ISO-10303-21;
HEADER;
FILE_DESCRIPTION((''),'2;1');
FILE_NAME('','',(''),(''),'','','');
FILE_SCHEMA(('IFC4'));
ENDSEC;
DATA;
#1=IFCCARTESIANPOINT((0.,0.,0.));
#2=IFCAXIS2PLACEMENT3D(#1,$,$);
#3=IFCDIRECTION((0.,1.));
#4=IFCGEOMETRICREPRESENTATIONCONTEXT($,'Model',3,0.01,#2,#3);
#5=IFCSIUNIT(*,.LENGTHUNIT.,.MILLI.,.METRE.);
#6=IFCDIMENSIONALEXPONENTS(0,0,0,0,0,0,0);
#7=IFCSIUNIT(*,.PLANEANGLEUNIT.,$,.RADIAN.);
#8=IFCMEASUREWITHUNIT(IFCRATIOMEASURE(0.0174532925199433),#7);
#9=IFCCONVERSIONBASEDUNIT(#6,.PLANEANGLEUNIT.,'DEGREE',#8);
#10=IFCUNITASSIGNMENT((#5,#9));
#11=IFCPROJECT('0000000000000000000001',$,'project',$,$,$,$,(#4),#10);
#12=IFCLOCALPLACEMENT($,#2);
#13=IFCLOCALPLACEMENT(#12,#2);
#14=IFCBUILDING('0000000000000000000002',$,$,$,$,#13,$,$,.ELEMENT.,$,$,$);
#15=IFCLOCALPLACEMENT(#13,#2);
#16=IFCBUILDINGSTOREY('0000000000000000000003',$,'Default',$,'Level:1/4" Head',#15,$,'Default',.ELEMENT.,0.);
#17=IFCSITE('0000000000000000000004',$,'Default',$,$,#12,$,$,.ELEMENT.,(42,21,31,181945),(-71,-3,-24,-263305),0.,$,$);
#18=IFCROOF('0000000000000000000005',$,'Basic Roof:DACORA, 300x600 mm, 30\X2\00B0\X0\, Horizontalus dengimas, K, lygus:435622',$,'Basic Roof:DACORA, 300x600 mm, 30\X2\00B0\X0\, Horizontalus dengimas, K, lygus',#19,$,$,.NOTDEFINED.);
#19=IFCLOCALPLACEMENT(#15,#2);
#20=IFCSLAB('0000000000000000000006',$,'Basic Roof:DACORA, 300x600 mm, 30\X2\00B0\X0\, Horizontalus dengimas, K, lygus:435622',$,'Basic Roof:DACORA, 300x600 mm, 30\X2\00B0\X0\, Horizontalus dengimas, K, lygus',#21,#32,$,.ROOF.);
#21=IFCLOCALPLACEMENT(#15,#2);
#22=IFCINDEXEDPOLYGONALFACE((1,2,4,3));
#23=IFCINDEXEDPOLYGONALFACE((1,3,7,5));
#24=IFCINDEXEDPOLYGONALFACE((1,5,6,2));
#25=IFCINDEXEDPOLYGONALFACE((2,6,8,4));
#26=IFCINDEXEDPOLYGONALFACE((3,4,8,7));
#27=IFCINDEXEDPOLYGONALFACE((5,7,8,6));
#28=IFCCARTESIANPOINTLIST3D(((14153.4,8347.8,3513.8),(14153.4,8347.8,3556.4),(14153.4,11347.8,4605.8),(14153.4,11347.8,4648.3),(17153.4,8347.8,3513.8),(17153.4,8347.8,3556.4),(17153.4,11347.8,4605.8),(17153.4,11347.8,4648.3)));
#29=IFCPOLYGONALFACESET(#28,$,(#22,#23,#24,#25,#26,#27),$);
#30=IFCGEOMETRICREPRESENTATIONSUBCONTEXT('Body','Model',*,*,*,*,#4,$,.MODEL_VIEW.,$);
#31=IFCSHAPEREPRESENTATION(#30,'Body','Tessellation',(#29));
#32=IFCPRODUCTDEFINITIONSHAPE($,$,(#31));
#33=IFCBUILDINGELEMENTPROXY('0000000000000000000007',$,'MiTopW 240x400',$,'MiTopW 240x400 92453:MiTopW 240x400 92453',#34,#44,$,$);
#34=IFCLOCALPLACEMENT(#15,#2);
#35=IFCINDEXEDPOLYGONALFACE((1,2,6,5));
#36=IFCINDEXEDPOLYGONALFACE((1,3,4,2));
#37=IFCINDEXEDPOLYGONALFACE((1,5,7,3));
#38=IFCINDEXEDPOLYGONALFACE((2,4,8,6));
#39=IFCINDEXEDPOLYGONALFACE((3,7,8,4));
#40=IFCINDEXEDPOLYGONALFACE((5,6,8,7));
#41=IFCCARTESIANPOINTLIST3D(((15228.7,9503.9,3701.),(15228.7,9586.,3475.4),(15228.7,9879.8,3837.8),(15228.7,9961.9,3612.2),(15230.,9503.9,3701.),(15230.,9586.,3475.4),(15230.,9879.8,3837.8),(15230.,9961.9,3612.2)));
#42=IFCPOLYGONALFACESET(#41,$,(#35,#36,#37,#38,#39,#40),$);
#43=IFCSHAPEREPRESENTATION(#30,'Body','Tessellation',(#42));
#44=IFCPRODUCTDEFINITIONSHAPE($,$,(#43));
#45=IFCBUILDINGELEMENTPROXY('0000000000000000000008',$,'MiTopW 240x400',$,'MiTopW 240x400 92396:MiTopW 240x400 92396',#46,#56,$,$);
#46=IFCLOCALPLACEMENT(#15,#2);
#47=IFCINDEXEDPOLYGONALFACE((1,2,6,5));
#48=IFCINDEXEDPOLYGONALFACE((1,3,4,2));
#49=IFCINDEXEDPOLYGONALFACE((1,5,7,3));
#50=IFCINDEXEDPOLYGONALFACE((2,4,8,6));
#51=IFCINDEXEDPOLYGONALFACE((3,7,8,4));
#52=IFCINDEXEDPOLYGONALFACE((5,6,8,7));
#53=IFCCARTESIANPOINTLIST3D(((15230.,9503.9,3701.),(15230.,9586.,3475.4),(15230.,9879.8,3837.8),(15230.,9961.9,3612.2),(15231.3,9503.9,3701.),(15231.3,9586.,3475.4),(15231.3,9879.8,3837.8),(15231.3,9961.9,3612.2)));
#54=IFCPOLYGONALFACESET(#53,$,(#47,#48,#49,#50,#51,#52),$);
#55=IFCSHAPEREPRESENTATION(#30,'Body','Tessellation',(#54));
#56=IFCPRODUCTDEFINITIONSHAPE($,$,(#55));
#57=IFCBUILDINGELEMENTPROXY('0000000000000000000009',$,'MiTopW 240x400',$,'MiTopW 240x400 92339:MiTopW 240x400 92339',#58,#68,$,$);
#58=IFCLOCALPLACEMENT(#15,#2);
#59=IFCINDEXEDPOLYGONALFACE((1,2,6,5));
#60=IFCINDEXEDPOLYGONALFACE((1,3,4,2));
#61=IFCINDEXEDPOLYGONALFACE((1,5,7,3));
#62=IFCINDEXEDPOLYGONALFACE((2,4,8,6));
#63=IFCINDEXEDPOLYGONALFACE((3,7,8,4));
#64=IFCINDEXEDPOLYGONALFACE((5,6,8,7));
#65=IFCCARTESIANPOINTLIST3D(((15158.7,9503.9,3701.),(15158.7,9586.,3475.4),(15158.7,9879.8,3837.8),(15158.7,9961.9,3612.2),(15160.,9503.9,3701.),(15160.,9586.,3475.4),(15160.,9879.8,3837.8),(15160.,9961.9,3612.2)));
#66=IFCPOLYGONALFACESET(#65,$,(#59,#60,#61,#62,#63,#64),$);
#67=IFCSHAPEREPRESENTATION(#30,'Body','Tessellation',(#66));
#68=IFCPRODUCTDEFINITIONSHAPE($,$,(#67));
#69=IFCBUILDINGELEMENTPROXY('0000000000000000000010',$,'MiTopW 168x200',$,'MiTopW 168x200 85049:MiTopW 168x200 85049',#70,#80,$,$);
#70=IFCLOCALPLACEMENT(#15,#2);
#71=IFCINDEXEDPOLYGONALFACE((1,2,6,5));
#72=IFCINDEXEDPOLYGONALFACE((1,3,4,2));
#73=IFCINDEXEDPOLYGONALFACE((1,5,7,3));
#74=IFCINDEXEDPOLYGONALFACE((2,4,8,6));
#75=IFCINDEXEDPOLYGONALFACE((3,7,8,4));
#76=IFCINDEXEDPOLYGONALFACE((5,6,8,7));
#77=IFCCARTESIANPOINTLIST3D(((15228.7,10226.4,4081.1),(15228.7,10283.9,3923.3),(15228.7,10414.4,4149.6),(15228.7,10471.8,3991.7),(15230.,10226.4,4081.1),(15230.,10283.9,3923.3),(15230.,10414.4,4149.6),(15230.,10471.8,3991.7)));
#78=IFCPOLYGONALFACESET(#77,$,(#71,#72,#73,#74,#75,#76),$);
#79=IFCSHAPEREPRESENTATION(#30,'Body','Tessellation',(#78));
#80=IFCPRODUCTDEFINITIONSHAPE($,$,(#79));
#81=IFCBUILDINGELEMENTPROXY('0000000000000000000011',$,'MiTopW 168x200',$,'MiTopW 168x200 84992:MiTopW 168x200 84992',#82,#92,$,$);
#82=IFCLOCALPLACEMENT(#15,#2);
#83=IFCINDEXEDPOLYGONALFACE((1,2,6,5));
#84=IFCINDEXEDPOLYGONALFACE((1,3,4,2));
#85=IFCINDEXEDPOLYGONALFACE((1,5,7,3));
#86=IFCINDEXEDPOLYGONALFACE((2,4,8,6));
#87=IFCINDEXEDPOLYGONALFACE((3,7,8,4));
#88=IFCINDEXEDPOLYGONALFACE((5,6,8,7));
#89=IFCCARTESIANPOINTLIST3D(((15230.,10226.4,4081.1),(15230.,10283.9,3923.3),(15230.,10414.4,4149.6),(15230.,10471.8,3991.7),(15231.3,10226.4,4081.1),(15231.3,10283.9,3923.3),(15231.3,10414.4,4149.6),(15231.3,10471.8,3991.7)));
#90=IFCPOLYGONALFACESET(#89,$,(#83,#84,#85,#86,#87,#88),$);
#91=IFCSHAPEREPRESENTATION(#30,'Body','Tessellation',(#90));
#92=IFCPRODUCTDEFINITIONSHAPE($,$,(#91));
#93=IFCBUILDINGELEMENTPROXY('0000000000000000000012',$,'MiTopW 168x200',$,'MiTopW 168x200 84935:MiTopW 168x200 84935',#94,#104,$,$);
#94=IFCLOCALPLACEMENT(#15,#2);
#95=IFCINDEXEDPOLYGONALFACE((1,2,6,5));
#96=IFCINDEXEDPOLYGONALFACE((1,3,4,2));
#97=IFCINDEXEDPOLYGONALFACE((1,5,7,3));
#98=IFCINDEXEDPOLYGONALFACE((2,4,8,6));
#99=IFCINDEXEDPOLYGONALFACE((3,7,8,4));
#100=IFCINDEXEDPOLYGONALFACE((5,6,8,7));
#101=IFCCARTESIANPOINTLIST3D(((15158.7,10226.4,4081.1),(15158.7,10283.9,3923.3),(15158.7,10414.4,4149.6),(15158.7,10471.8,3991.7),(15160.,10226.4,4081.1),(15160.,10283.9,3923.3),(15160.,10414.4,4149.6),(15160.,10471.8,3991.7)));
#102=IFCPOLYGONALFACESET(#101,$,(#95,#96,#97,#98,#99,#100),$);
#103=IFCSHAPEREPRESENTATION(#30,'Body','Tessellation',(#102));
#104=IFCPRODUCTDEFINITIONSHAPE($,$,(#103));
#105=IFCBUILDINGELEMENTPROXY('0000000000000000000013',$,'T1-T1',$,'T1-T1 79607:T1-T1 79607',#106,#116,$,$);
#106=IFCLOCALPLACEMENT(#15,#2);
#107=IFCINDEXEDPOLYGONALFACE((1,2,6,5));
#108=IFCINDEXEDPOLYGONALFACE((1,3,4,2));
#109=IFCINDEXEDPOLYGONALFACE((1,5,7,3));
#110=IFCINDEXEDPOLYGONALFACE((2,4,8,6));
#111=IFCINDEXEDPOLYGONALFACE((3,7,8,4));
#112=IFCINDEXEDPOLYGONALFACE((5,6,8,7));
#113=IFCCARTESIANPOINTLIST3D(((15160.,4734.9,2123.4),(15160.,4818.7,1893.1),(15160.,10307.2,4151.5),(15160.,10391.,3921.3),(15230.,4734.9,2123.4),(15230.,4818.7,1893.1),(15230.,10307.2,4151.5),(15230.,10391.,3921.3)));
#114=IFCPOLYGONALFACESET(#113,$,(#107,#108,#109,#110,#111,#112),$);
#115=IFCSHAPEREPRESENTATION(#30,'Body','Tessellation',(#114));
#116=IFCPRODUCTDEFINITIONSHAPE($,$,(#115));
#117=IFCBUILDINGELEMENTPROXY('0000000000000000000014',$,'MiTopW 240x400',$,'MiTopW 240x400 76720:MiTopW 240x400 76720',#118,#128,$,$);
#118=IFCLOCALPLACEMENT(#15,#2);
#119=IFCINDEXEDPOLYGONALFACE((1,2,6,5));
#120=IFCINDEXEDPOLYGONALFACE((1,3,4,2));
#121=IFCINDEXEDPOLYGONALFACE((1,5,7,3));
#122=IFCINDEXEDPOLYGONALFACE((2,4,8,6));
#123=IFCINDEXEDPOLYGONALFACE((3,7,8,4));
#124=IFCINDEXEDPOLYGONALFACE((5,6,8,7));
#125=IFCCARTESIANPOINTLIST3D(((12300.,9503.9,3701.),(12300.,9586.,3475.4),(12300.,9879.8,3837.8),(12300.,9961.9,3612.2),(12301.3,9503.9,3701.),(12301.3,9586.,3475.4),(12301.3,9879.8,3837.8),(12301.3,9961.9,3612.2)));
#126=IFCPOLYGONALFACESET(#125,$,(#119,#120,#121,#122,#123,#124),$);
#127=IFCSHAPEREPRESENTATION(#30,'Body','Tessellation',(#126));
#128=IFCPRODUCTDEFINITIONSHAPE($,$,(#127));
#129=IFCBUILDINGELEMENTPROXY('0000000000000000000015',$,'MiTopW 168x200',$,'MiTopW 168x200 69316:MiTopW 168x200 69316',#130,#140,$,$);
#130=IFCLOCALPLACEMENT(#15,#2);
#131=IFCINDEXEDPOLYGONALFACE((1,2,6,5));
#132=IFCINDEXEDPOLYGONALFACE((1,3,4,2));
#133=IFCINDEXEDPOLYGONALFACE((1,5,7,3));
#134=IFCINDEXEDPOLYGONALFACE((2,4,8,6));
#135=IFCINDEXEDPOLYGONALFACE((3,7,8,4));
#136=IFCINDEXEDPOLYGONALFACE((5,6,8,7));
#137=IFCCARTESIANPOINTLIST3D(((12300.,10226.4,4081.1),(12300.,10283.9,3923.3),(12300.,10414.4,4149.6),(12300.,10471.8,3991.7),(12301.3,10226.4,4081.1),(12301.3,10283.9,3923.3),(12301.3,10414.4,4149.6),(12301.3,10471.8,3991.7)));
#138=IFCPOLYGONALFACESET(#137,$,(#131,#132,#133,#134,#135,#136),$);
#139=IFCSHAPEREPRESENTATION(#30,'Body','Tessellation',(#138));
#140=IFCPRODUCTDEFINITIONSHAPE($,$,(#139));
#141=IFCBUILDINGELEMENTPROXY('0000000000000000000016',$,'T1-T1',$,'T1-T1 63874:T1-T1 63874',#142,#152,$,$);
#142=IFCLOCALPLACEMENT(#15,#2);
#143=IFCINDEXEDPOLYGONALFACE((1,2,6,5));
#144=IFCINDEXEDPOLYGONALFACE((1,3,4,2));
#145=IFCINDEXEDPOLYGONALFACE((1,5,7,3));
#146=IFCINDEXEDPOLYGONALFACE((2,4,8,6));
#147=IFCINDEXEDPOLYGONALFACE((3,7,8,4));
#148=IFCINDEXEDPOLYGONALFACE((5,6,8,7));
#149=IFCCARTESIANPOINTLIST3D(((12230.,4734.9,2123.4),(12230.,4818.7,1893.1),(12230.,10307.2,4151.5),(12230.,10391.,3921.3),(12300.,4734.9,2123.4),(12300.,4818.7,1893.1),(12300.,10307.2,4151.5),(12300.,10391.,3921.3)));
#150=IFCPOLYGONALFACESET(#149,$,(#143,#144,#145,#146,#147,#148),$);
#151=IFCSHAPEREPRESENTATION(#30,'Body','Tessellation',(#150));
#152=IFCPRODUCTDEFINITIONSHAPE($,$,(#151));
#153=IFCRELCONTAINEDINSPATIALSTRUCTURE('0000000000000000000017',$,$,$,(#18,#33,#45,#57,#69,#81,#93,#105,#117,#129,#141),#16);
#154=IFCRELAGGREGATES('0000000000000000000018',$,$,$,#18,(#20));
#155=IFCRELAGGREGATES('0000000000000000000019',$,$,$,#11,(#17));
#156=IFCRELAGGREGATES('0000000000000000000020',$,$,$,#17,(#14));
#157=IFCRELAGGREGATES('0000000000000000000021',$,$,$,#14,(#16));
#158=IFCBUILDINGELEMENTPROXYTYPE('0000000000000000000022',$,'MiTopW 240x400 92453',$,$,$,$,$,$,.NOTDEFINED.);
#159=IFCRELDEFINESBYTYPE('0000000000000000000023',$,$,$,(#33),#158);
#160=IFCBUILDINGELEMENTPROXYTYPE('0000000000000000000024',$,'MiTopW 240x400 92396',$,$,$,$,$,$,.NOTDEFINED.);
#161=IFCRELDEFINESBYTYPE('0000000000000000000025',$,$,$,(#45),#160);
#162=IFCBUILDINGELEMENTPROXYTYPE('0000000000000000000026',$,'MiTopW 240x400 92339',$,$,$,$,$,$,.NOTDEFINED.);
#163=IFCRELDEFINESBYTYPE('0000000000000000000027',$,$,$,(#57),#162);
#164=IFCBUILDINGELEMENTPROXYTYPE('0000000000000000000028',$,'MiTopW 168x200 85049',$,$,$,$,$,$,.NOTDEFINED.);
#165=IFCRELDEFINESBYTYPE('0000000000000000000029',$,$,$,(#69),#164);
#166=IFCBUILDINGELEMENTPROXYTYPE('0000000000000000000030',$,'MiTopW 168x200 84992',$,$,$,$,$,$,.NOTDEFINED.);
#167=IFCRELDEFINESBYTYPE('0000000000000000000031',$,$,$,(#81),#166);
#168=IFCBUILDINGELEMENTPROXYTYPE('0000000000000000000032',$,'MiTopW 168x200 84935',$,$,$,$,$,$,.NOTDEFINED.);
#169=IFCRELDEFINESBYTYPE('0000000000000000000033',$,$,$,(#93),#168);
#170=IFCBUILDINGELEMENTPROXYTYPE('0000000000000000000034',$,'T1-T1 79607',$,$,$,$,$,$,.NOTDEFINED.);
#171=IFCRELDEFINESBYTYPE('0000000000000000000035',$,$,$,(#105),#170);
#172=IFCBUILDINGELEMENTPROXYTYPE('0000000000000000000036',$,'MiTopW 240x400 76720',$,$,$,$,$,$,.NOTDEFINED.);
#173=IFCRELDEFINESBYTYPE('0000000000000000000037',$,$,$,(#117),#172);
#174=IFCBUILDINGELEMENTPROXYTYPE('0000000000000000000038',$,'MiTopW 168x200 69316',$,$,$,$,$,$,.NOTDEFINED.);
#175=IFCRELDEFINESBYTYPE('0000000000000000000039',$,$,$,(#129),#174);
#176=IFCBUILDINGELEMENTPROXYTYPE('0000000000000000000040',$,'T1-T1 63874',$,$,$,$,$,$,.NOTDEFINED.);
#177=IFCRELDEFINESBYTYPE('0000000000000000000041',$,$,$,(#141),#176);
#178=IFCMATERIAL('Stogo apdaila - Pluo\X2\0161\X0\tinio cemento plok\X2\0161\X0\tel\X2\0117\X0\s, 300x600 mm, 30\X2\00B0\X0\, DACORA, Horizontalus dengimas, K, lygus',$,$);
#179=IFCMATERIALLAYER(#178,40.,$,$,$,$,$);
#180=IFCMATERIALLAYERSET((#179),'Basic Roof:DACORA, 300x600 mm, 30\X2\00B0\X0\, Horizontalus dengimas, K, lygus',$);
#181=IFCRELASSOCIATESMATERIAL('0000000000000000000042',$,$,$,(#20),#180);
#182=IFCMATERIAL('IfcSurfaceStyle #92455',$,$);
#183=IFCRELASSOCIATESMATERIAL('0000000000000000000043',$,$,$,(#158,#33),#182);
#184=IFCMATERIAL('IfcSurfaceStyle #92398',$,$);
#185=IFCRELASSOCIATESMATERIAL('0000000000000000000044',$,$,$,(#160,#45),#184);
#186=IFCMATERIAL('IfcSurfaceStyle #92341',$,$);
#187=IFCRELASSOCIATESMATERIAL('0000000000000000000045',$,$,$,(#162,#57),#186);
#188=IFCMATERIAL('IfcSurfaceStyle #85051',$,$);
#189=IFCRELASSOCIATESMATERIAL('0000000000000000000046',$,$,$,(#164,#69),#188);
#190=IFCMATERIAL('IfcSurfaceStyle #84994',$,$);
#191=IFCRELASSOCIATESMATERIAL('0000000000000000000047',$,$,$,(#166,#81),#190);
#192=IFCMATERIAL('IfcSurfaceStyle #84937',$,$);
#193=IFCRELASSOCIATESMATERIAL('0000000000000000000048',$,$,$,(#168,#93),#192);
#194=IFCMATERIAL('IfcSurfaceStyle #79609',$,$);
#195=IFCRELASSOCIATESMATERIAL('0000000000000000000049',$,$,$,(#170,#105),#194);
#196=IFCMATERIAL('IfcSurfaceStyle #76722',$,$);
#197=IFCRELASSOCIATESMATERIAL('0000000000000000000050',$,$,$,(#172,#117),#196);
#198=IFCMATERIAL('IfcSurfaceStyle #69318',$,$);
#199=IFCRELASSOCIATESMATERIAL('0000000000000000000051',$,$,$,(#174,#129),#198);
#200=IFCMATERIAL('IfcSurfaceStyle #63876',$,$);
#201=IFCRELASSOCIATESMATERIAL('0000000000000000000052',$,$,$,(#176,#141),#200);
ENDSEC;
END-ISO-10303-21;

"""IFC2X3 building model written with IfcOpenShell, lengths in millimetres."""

from ifc_helpers import new_model, entity, si_unit, converted_unit, direction, frame, frame_2d, origin, place, context, subcontext, project, spatial, polyline, rectangle, outline, extrude, source, transform, mapped, material, layer, layer_set, type_object, type_shapes, element, aggregate, save


model = new_model("IFC2X3")

# Units and contexts
model_context = context("Model", 3, precision=0.01, world=origin(), true_north=direction((0.0, 1.0)))
body_context = subcontext(model_context, "Body", "Model", "MODEL_VIEW")
ifc_project = project(units=[si_unit("LENGTHUNIT", "METRE", prefix="MILLI"), converted_unit("PLANEANGLEUNIT", "DEGREE", entity("IfcRatioMeasure", 0.0174532925199433), si_unit("PLANEANGLEUNIT", "RADIAN"), dimensions=[0, 0, 0, 0, 0, 0, 0])], contexts=[model_context])

# Site, building, storey
site_placement = place(None, origin())
site = spatial("IfcSite", under=ifc_project, at=site_placement, Name="Default", CompositionType="ELEMENT", RefLatitude=(42, 21, 31, 181945), RefLongitude=(-71, -3, -24, -263305), RefElevation=0.0)
building_placement = place(site_placement, origin())
building = spatial("IfcBuilding", under=site, at=building_placement, CompositionType="ELEMENT")
storey_placement = place(building_placement, origin())
storey = spatial("IfcBuildingStorey", under=building, at=storey_placement, Name="Default", ObjectType="Level:1/4\" Head", LongName="Default", CompositionType="ELEMENT", Elevation=0.0)

# Roof, slab
roof_placement = place(storey_placement, frame((14153.4, 8347.8, 3513.8)))
roof = element("IfcRoof", 1, at=roof_placement, inside=storey, Name="Basic Roof:DACORA, 300x600 mm, 30°, Horizontalus dengimas, K, lygus:435622", ObjectType="Basic Roof:DACORA, 300x600 mm, 30°, Horizontalus dengimas, K, lygus", ShapeType="NOTDEFINED")
ifc_material_1 = material(Name="Stogo apdaila - Pluoštinio cemento plokštelės, 300x600 mm, 30°, DACORA, Horizontalus dengimas, K, lygus")
ifc_layer = layer(ifc_material_1, 40.0)
ifc_layer_set = layer_set([ifc_layer], Name="Basic Roof:DACORA, 300x600 mm, 30°, Horizontalus dengimas, K, lygus")
slab_placement = place(roof_placement, origin())
slab = element("IfcSlab", 2, at=slab_placement, material=ifc_layer_set, Name="Basic Roof:DACORA, 300x600 mm, 30°, Horizontalus dengimas, K, lygus:435622", ObjectType="Basic Roof:DACORA, 300x600 mm, 30°, Horizontalus dengimas, K, lygus", PredefinedType="ROOF", context=body_context, shape_type="SweptSolid", body=[
    extrude(rectangle(XDim=3192.5, YDim=3000.0, at=frame_2d((0.0, 0.0), x_axis=(0.0, -1.0))), frame((1500.0, 1500.0, 546.0), z_axis=(0.0, -0.34202, 0.939693), x_axis=(1.0, 0.0, 0.0)), (0.0, 0.34202, 0.939693), 42.6),
])
aggregate(roof, [slab])

# Building element proxies
ifc_material_2 = material(Name="IfcSurfaceStyle #92455")
building_element_proxy_type_1 = type_object("IfcBuildingElementProxyType", Name="MiTopW 240x400 92453", PredefinedType="NOTDEFINED", material=ifc_material_2)
shared_shape_1 = source(origin(), body_context, "Body", "SweptSolid", [
    extrude(outline(polyline([(-200.0, -120.0), (200.0, -120.0), (200.0, 120.0), (-200.0, 120.0), (-200.0, -120.0)])), frame((200.0, 120.0, 0.0), z_axis=(0.0, 0.0, 1.0), x_axis=(-1.0, 0.0, 0.0)), (0.0, 0.0, 1.0), 1.3),
])
type_shapes(building_element_proxy_type_1, [shared_shape_1])
proxy_1_placement = place(building_placement, frame((15230.0, 9961.9, 3612.2), z_axis=(-1.0, 0.0, 0.0), x_axis=(0.0, -0.939693, -0.34202)))
element("IfcBuildingElementProxy", 3, at=proxy_1_placement, inside=storey, type_object=building_element_proxy_type_1, material=ifc_material_2, Name="MiTopW 240x400", ObjectType="MiTopW 240x400 92453:MiTopW 240x400 92453", context=body_context, shape_type="MappedRepresentation", body=[
    mapped(shared_shape_1, transform((0.0, 0.0, 0.0), scale=1.0)),
])
ifc_material_3 = material(Name="IfcSurfaceStyle #92398")
building_element_proxy_type_2 = type_object("IfcBuildingElementProxyType", Name="MiTopW 240x400 92396", PredefinedType="NOTDEFINED", material=ifc_material_3)
shared_shape_2 = source(origin(), body_context, "Body", "SweptSolid", [
    extrude(outline(polyline([(-200.0, -120.0), (200.0, -120.0), (200.0, 120.0), (-200.0, 120.0), (-200.0, -120.0)])), frame((200.0, 120.0, 0.0), z_axis=(0.0, 0.0, 1.0), x_axis=(-1.0, 0.0, 0.0)), (0.0, 0.0, 1.0), 1.3),
])
type_shapes(building_element_proxy_type_2, [shared_shape_2])
proxy_2_placement = place(building_placement, frame((15231.3, 9961.9, 3612.2), z_axis=(-1.0, 0.0, 0.0), x_axis=(0.0, -0.939693, -0.34202)))
element("IfcBuildingElementProxy", 4, at=proxy_2_placement, inside=storey, type_object=building_element_proxy_type_2, material=ifc_material_3, Name="MiTopW 240x400", ObjectType="MiTopW 240x400 92396:MiTopW 240x400 92396", context=body_context, shape_type="MappedRepresentation", body=[
    mapped(shared_shape_2, transform((0.0, 0.0, 0.0), scale=1.0)),
])
ifc_material_4 = material(Name="IfcSurfaceStyle #92341")
building_element_proxy_type_3 = type_object("IfcBuildingElementProxyType", Name="MiTopW 240x400 92339", PredefinedType="NOTDEFINED", material=ifc_material_4)
shared_shape_3 = source(origin(), body_context, "Body", "SweptSolid", [
    extrude(outline(polyline([(-200.0, -120.0), (200.0, -120.0), (200.0, 120.0), (-200.0, 120.0), (-200.0, -120.0)])), frame((200.0, 120.0, 0.0), z_axis=(0.0, 0.0, 1.0), x_axis=(-1.0, 0.0, 0.0)), (0.0, 0.0, 1.0), 1.3),
])
type_shapes(building_element_proxy_type_3, [shared_shape_3])
proxy_3_placement = place(building_placement, frame((15160.0, 9961.9, 3612.2), z_axis=(-1.0, 0.0, 0.0), x_axis=(0.0, -0.939693, -0.34202)))
element("IfcBuildingElementProxy", 5, at=proxy_3_placement, inside=storey, type_object=building_element_proxy_type_3, material=ifc_material_4, Name="MiTopW 240x400", ObjectType="MiTopW 240x400 92339:MiTopW 240x400 92339", context=body_context, shape_type="MappedRepresentation", body=[
    mapped(shared_shape_3, transform((0.0, 0.0, 0.0), scale=1.0)),
])
ifc_material_5 = material(Name="IfcSurfaceStyle #85051")
building_element_proxy_type_4 = type_object("IfcBuildingElementProxyType", Name="MiTopW 168x200 85049", PredefinedType="NOTDEFINED", material=ifc_material_5)
shared_shape_4 = source(origin(), body_context, "Body", "SweptSolid", [
    extrude(outline(polyline([(-100.0, -84.0), (100.0, -84.0), (100.0, 84.0), (-100.0, 84.0), (-100.0, -84.0)])), frame((100.0, 84.0, 0.0), z_axis=(0.0, 0.0, 1.0), x_axis=(-1.0, 0.0, 0.0)), (0.0, 0.0, 1.0), 1.3),
])
type_shapes(building_element_proxy_type_4, [shared_shape_4])
proxy_4_placement = place(building_placement, frame((15230.0, 10226.4, 4081.1), z_axis=(-1.0, 0.0, 0.0), x_axis=(0.0, 0.939693, 0.34202)))
element("IfcBuildingElementProxy", 6, at=proxy_4_placement, inside=storey, type_object=building_element_proxy_type_4, material=ifc_material_5, Name="MiTopW 168x200", ObjectType="MiTopW 168x200 85049:MiTopW 168x200 85049", context=body_context, shape_type="MappedRepresentation", body=[
    mapped(shared_shape_4, transform((0.0, 0.0, 0.0), scale=1.0)),
])
ifc_material_6 = material(Name="IfcSurfaceStyle #84994")
building_element_proxy_type_5 = type_object("IfcBuildingElementProxyType", Name="MiTopW 168x200 84992", PredefinedType="NOTDEFINED", material=ifc_material_6)
shared_shape_5 = source(origin(), body_context, "Body", "SweptSolid", [
    extrude(outline(polyline([(-100.0, -84.0), (100.0, -84.0), (100.0, 84.0), (-100.0, 84.0), (-100.0, -84.0)])), frame((100.0, 84.0, 0.0), z_axis=(0.0, 0.0, 1.0), x_axis=(-1.0, 0.0, 0.0)), (0.0, 0.0, 1.0), 1.3),
])
type_shapes(building_element_proxy_type_5, [shared_shape_5])
proxy_5_placement = place(building_placement, frame((15231.3, 10226.4, 4081.1), z_axis=(-1.0, 0.0, 0.0), x_axis=(0.0, 0.939693, 0.34202)))
element("IfcBuildingElementProxy", 7, at=proxy_5_placement, inside=storey, type_object=building_element_proxy_type_5, material=ifc_material_6, Name="MiTopW 168x200", ObjectType="MiTopW 168x200 84992:MiTopW 168x200 84992", context=body_context, shape_type="MappedRepresentation", body=[
    mapped(shared_shape_5, transform((0.0, 0.0, 0.0), scale=1.0)),
])
ifc_material_7 = material(Name="IfcSurfaceStyle #84937")
building_element_proxy_type_6 = type_object("IfcBuildingElementProxyType", Name="MiTopW 168x200 84935", PredefinedType="NOTDEFINED", material=ifc_material_7)
shared_shape_6 = source(origin(), body_context, "Body", "SweptSolid", [
    extrude(outline(polyline([(-100.0, -84.0), (100.0, -84.0), (100.0, 84.0), (-100.0, 84.0), (-100.0, -84.0)])), frame((100.0, 84.0, 0.0), z_axis=(0.0, 0.0, 1.0), x_axis=(-1.0, 0.0, 0.0)), (0.0, 0.0, 1.0), 1.3),
])
type_shapes(building_element_proxy_type_6, [shared_shape_6])
proxy_6_placement = place(building_placement, frame((15160.0, 10226.4, 4081.1), z_axis=(-1.0, 0.0, 0.0), x_axis=(0.0, 0.939693, 0.34202)))
element("IfcBuildingElementProxy", 8, at=proxy_6_placement, inside=storey, type_object=building_element_proxy_type_6, material=ifc_material_7, Name="MiTopW 168x200", ObjectType="MiTopW 168x200 84935:MiTopW 168x200 84935", context=body_context, shape_type="MappedRepresentation", body=[
    mapped(shared_shape_6, transform((0.0, 0.0, 0.0), scale=1.0)),
])
ifc_material_8 = material(Name="IfcSurfaceStyle #79609")
building_element_proxy_type_7 = type_object("IfcBuildingElementProxyType", Name="T1-T1 79607", PredefinedType="NOTDEFINED", material=ifc_material_8)
shared_shape_7 = source(origin(), body_context, "Body", "SweptSolid", [
    extrude(outline(polyline([(-2965.0, -122.5), (2965.0, -122.5), (2965.0, 122.5), (-2965.0, 122.5), (-2965.0, -122.5)])), frame((2965.0, 122.5, 0.0), z_axis=(0.0, 0.0, 1.0), x_axis=(-1.0, 0.0, 0.0)), (0.0, 0.0, 1.0), 70.0),
])
type_shapes(building_element_proxy_type_7, [shared_shape_7])
proxy_7_placement = place(building_placement, frame((15230.0, 10391.0, 3921.3), z_axis=(-1.0, 0.0, 0.0), x_axis=(0.0, -0.939693, -0.34202)))
element("IfcBuildingElementProxy", 9, at=proxy_7_placement, inside=storey, type_object=building_element_proxy_type_7, material=ifc_material_8, Name="T1-T1", ObjectType="T1-T1 79607:T1-T1 79607", context=body_context, shape_type="MappedRepresentation", body=[
    mapped(shared_shape_7, transform((0.0, 0.0, 0.0), scale=1.0)),
])
ifc_material_9 = material(Name="IfcSurfaceStyle #76722")
building_element_proxy_type_8 = type_object("IfcBuildingElementProxyType", Name="MiTopW 240x400 76720", PredefinedType="NOTDEFINED", material=ifc_material_9)
shared_shape_8 = source(origin(), body_context, "Body", "SweptSolid", [
    extrude(outline(polyline([(-200.0, -120.0), (200.0, -120.0), (200.0, 120.0), (-200.0, 120.0), (-200.0, -120.0)])), frame((200.0, 120.0, 0.0), z_axis=(0.0, 0.0, 1.0), x_axis=(-1.0, 0.0, 0.0)), (0.0, 0.0, 1.0), 1.3),
])
type_shapes(building_element_proxy_type_8, [shared_shape_8])
proxy_8_placement = place(building_placement, frame((12301.3, 9961.9, 3612.2), z_axis=(-1.0, 0.0, 0.0), x_axis=(0.0, -0.939693, -0.34202)))
element("IfcBuildingElementProxy", 10, at=proxy_8_placement, inside=storey, type_object=building_element_proxy_type_8, material=ifc_material_9, Name="MiTopW 240x400", ObjectType="MiTopW 240x400 76720:MiTopW 240x400 76720", context=body_context, shape_type="MappedRepresentation", body=[
    mapped(shared_shape_8, transform((0.0, 0.0, 0.0), scale=1.0)),
])
ifc_material_10 = material(Name="IfcSurfaceStyle #69318")
building_element_proxy_type_9 = type_object("IfcBuildingElementProxyType", Name="MiTopW 168x200 69316", PredefinedType="NOTDEFINED", material=ifc_material_10)
shared_shape_9 = source(origin(), body_context, "Body", "SweptSolid", [
    extrude(outline(polyline([(-100.0, -84.0), (100.0, -84.0), (100.0, 84.0), (-100.0, 84.0), (-100.0, -84.0)])), frame((100.0, 84.0, 0.0), z_axis=(0.0, 0.0, 1.0), x_axis=(-1.0, 0.0, 0.0)), (0.0, 0.0, 1.0), 1.3),
])
type_shapes(building_element_proxy_type_9, [shared_shape_9])
proxy_9_placement = place(building_placement, frame((12301.3, 10226.4, 4081.1), z_axis=(-1.0, 0.0, 0.0), x_axis=(0.0, 0.939693, 0.34202)))
element("IfcBuildingElementProxy", 11, at=proxy_9_placement, inside=storey, type_object=building_element_proxy_type_9, material=ifc_material_10, Name="MiTopW 168x200", ObjectType="MiTopW 168x200 69316:MiTopW 168x200 69316", context=body_context, shape_type="MappedRepresentation", body=[
    mapped(shared_shape_9, transform((0.0, 0.0, 0.0), scale=1.0)),
])
ifc_material_11 = material(Name="IfcSurfaceStyle #63876")
building_element_proxy_type_10 = type_object("IfcBuildingElementProxyType", Name="T1-T1 63874", PredefinedType="NOTDEFINED", material=ifc_material_11)
shared_shape_10 = source(origin(), body_context, "Body", "SweptSolid", [
    extrude(outline(polyline([(-2965.0, -122.5), (2965.0, -122.5), (2965.0, 122.5), (-2965.0, 122.5), (-2965.0, -122.5)])), frame((2965.0, 122.5, 0.0), z_axis=(0.0, 0.0, 1.0), x_axis=(-1.0, 0.0, 0.0)), (0.0, 0.0, 1.0), 70.0),
])
type_shapes(building_element_proxy_type_10, [shared_shape_10])
proxy_10_placement = place(building_placement, frame((12300.0, 10391.0, 3921.3), z_axis=(-1.0, 0.0, 0.0), x_axis=(0.0, -0.939693, -0.34202)))
element("IfcBuildingElementProxy", 12, at=proxy_10_placement, inside=storey, type_object=building_element_proxy_type_10, material=ifc_material_11, Name="T1-T1", ObjectType="T1-T1 63874:T1-T1 63874", context=body_context, shape_type="MappedRepresentation", body=[
    mapped(shared_shape_10, transform((0.0, 0.0, 0.0), scale=1.0)),
])

save(model, "model.ifc")
